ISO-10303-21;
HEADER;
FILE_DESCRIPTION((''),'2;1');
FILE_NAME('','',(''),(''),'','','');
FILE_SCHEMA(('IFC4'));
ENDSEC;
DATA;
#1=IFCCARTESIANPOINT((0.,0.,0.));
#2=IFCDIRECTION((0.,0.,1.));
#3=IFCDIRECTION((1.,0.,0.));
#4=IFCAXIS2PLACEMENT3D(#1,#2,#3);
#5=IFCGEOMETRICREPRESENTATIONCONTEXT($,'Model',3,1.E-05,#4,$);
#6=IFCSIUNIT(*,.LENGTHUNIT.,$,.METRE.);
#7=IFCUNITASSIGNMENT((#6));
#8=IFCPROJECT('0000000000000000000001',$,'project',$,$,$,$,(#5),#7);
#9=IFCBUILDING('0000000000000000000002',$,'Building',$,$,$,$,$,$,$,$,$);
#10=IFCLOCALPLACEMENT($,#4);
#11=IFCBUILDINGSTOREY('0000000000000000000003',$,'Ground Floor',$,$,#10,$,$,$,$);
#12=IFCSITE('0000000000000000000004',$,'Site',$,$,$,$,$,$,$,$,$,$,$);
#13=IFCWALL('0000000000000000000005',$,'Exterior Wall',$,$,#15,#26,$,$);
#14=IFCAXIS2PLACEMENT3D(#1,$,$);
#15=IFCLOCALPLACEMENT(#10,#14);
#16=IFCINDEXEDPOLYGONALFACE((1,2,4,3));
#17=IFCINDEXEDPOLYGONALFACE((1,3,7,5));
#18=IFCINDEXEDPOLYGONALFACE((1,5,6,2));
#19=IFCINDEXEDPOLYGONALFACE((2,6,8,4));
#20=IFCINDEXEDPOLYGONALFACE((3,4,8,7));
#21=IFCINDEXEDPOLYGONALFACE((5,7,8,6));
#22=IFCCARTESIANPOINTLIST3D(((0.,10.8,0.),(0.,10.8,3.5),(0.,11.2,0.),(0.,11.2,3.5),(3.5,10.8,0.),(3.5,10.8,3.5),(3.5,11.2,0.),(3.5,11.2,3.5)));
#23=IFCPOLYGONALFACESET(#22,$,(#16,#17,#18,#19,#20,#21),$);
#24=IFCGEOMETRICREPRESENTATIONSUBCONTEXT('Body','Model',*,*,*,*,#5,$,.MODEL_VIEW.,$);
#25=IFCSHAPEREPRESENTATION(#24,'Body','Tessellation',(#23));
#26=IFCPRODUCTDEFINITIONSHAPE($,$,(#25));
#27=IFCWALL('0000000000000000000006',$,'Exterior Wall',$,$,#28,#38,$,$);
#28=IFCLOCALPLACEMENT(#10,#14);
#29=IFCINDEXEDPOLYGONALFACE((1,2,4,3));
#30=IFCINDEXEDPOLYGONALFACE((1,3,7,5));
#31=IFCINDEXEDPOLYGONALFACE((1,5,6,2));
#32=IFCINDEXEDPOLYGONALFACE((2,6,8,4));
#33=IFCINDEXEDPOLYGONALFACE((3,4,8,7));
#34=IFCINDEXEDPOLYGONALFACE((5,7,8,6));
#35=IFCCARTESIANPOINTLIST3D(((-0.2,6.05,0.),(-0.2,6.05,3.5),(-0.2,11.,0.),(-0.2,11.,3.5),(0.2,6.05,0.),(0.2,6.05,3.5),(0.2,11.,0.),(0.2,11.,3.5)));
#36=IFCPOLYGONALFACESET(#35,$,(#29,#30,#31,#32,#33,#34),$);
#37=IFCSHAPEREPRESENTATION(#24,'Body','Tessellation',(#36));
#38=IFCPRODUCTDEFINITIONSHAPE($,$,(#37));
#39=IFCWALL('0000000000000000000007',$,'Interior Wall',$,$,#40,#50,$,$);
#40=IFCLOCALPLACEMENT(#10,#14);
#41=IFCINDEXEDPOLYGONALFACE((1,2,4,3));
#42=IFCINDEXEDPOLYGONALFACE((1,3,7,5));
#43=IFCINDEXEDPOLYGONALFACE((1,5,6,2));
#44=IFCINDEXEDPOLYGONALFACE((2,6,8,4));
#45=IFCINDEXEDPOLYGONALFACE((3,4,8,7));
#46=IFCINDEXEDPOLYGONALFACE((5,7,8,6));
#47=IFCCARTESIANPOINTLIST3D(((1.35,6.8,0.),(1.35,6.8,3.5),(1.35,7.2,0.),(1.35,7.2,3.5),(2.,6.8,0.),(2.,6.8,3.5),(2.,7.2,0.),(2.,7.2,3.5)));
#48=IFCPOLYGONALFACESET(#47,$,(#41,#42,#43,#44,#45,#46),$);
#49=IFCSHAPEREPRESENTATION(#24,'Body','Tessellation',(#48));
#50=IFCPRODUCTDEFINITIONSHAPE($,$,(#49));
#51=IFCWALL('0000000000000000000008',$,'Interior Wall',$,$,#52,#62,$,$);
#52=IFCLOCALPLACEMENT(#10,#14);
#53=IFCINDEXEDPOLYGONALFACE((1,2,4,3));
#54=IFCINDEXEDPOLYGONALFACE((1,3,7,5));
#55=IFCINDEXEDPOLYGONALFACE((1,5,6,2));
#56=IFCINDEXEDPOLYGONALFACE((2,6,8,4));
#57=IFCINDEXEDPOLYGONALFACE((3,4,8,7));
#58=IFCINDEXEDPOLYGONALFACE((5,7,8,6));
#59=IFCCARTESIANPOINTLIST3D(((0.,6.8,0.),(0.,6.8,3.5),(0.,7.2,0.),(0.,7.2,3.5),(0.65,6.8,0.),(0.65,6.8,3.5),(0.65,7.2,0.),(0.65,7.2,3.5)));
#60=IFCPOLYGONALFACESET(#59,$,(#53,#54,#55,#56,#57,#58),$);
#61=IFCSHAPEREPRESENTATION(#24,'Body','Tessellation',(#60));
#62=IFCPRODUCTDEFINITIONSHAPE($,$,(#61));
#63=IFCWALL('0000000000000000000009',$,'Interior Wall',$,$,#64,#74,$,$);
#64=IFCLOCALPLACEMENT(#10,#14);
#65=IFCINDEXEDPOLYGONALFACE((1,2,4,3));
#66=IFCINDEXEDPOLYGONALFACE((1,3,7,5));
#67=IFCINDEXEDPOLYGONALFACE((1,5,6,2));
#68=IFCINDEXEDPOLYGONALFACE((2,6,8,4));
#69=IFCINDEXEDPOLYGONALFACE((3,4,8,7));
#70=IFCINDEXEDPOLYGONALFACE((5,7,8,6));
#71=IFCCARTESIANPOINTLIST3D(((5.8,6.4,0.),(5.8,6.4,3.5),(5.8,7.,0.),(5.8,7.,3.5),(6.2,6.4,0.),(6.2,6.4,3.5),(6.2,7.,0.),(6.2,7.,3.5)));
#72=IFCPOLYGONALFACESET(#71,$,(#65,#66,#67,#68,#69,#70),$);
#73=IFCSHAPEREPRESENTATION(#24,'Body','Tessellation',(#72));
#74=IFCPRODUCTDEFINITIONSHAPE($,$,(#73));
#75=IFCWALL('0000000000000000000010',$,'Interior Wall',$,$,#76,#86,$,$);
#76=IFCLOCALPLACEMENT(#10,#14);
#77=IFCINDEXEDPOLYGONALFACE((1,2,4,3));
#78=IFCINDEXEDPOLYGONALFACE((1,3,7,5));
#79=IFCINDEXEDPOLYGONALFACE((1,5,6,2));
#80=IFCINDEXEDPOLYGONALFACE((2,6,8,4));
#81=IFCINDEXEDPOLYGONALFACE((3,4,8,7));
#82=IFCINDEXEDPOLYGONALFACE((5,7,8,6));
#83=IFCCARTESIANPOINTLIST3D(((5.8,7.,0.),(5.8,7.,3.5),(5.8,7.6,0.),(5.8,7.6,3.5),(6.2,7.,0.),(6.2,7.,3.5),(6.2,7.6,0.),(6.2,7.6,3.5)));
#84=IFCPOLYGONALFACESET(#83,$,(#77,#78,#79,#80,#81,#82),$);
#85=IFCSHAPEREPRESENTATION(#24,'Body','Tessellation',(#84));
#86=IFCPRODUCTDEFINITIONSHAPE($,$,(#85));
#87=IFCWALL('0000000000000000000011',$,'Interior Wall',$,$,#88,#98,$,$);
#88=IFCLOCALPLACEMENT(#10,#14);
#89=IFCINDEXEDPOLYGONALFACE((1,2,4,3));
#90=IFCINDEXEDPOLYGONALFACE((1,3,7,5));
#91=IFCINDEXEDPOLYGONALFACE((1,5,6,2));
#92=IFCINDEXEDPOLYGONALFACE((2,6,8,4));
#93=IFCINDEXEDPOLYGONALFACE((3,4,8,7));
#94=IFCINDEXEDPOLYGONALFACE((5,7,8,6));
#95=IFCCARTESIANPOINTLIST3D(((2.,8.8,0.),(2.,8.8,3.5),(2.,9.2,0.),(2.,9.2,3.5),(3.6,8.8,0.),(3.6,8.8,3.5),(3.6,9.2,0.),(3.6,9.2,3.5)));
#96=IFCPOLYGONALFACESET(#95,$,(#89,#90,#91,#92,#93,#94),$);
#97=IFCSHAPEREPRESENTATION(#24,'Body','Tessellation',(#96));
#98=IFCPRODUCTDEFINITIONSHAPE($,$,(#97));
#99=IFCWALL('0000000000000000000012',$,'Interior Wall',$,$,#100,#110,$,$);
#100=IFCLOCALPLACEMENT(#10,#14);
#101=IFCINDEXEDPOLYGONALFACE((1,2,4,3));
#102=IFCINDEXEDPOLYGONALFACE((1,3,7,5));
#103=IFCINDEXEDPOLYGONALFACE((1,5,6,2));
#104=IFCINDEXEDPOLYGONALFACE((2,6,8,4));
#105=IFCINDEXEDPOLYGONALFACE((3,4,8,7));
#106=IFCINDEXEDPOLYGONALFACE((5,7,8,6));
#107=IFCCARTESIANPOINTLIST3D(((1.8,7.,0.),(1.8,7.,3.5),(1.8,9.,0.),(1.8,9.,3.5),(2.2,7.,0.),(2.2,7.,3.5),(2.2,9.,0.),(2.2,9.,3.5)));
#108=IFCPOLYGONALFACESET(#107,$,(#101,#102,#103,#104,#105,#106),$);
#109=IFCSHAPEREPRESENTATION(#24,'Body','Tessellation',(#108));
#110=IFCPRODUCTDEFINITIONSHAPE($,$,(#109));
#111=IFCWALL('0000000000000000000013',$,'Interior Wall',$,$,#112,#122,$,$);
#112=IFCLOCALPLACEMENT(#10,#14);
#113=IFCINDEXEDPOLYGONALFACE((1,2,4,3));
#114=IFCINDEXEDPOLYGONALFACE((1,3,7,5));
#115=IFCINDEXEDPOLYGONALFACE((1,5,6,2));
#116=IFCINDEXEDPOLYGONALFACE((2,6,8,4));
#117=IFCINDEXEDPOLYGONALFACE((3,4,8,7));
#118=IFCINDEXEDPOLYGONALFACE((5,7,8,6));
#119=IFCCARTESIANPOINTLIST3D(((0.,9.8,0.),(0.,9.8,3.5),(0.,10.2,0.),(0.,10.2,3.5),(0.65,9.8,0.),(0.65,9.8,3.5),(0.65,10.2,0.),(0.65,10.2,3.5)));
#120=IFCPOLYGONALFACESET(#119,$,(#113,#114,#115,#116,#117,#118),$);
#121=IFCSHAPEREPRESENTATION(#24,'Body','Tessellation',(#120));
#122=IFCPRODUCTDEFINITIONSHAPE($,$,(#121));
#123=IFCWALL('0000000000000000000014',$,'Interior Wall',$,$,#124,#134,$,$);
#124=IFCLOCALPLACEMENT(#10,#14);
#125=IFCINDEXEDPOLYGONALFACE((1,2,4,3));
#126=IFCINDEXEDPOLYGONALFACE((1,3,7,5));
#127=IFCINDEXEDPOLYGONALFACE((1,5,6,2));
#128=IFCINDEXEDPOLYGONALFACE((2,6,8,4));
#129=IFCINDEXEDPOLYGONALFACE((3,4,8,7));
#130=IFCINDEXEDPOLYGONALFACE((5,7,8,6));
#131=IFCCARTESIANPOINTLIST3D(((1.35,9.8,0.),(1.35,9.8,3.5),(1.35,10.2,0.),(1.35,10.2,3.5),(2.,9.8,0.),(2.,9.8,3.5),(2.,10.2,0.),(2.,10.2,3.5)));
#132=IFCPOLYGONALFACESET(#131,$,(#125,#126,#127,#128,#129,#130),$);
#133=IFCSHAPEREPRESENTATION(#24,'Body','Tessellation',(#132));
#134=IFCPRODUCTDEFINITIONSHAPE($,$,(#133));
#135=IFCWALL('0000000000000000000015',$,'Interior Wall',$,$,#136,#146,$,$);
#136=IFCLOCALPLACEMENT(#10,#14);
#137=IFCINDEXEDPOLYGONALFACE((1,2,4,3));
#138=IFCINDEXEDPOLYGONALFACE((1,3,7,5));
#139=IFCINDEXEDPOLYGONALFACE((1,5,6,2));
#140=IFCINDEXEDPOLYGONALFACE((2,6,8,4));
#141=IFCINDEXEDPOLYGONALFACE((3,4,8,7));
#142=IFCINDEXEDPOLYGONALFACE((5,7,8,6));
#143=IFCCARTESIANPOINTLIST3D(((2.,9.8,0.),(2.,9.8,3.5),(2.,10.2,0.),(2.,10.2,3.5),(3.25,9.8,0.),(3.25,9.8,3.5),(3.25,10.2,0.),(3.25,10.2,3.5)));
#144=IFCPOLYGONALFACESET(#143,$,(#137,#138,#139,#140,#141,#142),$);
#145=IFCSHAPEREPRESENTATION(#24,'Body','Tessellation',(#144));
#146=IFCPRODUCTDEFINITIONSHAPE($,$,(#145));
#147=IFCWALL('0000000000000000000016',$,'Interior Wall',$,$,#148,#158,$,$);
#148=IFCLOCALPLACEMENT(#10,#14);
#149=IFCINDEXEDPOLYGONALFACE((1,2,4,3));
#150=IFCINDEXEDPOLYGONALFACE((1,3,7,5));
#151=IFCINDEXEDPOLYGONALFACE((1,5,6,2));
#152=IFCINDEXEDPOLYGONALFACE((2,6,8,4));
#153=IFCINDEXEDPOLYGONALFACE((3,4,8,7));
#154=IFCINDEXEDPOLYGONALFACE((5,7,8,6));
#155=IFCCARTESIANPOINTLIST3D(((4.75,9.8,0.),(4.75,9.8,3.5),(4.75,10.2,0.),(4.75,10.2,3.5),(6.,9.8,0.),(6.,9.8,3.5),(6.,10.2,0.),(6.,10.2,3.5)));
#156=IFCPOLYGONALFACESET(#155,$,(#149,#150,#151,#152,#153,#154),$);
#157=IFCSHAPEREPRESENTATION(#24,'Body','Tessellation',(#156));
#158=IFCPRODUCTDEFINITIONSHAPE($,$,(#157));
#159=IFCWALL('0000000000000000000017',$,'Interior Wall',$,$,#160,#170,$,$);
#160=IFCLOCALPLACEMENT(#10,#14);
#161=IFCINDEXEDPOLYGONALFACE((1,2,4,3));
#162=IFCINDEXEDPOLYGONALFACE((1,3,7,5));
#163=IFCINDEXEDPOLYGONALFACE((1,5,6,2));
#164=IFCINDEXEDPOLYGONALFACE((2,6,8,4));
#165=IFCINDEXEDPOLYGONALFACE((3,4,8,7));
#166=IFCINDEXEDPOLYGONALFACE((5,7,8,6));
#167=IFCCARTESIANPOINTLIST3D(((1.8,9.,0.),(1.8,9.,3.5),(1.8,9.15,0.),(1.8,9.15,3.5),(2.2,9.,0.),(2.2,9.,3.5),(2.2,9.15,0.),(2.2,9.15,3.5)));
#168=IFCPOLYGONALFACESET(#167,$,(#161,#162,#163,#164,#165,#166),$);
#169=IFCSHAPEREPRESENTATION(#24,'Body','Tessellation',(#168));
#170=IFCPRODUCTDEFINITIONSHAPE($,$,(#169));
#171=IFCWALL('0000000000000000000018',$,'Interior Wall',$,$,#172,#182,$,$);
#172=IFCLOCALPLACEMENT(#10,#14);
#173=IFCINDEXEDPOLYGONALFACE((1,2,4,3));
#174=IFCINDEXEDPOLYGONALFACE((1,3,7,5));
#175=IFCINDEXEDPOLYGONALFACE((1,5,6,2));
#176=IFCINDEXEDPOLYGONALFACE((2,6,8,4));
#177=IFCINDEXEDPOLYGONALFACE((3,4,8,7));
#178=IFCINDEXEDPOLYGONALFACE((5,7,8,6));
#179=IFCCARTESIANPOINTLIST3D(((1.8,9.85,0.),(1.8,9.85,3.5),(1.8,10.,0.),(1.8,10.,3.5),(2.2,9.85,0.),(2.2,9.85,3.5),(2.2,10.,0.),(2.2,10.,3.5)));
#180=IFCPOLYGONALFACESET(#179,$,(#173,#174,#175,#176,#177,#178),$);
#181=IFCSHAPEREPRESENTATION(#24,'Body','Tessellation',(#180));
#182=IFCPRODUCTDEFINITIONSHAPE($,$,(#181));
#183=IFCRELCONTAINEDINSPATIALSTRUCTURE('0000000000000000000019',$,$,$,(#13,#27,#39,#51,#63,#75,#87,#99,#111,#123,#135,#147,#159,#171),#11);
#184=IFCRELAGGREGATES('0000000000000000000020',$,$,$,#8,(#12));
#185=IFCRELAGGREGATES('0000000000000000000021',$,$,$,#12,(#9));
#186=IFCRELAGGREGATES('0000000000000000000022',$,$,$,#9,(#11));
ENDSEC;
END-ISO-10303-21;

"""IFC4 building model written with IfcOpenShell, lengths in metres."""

from ifc_helpers import new_model, si_unit, frame, origin_with_axes, place, context, subcontext, project, spatial, indexed_curve, outline, extrude, element, save


model = new_model("IFC4")

# Units and contexts
model_context = context("Model", 3, precision=1e-05, world=origin_with_axes())
body_context = subcontext(model_context, "Body", "Model", "MODEL_VIEW")
ifc_project = project(units=[si_unit("LENGTHUNIT", "METRE")], contexts=[model_context])

# Site, building, storey
site = spatial("IfcSite", under=ifc_project, Name="Site")
building = spatial("IfcBuilding", under=site, Name="Building")
storey_placement = place(None, origin_with_axes())
storey = spatial("IfcBuildingStorey", under=building, at=storey_placement, Name="Ground Floor")

# Walls
wall_1_placement = place(storey_placement, frame((3.5, 11.0, 0.0), z_axis=(0.0, 0.0, 1.0), x_axis=(-1.0, 0.0, 0.0)))
element("IfcWall", 1, at=wall_1_placement, inside=storey, Name="Exterior Wall", context=body_context, shape_type="SweptSolid", body=[
    extrude(outline(indexed_curve([(0.0, 0.0), (0.0, 0.4), (3.5, 0.4), (3.5, 0.0), (0.0, 0.0)], self_intersect=False)), frame((0.0, -0.2, 0.0), z_axis=(0.0, 0.0, 1.0), x_axis=(1.0, 0.0, 0.0)), (0.0, 0.0, 1.0), 3.5),
])
wall_2_placement = place(storey_placement, frame((0.0, 11.0, 0.0), z_axis=(0.0, 0.0, 1.0), x_axis=(0.0, -1.0, 0.0)))
element("IfcWall", 2, at=wall_2_placement, inside=storey, Name="Exterior Wall", context=body_context, shape_type="SweptSolid", body=[
    extrude(outline(indexed_curve([(0.0, 0.0), (0.0, 0.4), (4.95, 0.4), (4.95, 0.0), (0.0, 0.0)], self_intersect=False)), frame((0.0, -0.2, 0.0), z_axis=(0.0, 0.0, 1.0), x_axis=(1.0, 0.0, 0.0)), (0.0, 0.0, 1.0), 3.5),
])
for number, where, z_axis, x_axis, name in (
    (3, (2.0, 7.0, 0.0), (0.0, 0.0, 1.0), (-1.0, 0.0, 0.0), "Interior Wall"),
    (4, (0.65, 7.0, 0.0), (0.0, 0.0, 1.0), (-1.0, 0.0, 0.0), "Interior Wall"),
):
    element("IfcWall", number, at=place(storey_placement, frame(where, z_axis=z_axis, x_axis=x_axis)), inside=storey, Name=name, context=body_context, shape_type="SweptSolid", body=[
        extrude(outline(indexed_curve([(0.0, 0.0), (0.0, 0.4), (0.65, 0.4), (0.65, 0.0), (0.0, 0.0)], self_intersect=False)), frame((0.0, -0.2, 0.0), z_axis=(0.0, 0.0, 1.0), x_axis=(1.0, 0.0, 0.0)), (0.0, 0.0, 1.0), 3.5),
    ])
for number, where, z_axis, x_axis, name in (
    (5, (6.0, 6.4, 0.0), (0.0, 0.0, 1.0), (0.0, 1.0, 0.0), "Interior Wall"),
    (6, (6.0, 7.0, 0.0), (0.0, 0.0, 1.0), (0.0, 1.0, 0.0), "Interior Wall"),
):
    element("IfcWall", number, at=place(storey_placement, frame(where, z_axis=z_axis, x_axis=x_axis)), inside=storey, Name=name, context=body_context, shape_type="SweptSolid", body=[
        extrude(outline(indexed_curve([(0.0, 0.0), (0.0, 0.4), (0.6, 0.4), (0.6, 0.0), (0.0, 0.0)], self_intersect=False)), frame((0.0, -0.2, 0.0), z_axis=(0.0, 0.0, 1.0), x_axis=(1.0, 0.0, 0.0)), (0.0, 0.0, 1.0), 3.5),
    ])
wall_3_placement = place(storey_placement, frame((3.6, 9.0, 0.0), z_axis=(0.0, 0.0, 1.0), x_axis=(-1.0, 0.0, 0.0)))
element("IfcWall", 7, at=wall_3_placement, inside=storey, Name="Interior Wall", context=body_context, shape_type="SweptSolid", body=[
    extrude(outline(indexed_curve([(0.0, 0.0), (0.0, 0.4), (1.6, 0.4), (1.6, 0.0), (0.0, 0.0)], self_intersect=False)), frame((0.0, -0.2, 0.0), z_axis=(0.0, 0.0, 1.0), x_axis=(1.0, 0.0, 0.0)), (0.0, 0.0, 1.0), 3.5),
])
wall_4_placement = place(storey_placement, frame((2.0, 9.0, 0.0), z_axis=(0.0, 0.0, 1.0), x_axis=(0.0, -1.0, 0.0)))
element("IfcWall", 8, at=wall_4_placement, inside=storey, Name="Interior Wall", context=body_context, shape_type="SweptSolid", body=[
    extrude(outline(indexed_curve([(0.0, 0.0), (0.0, 0.4), (2.0, 0.4), (2.0, 0.0), (0.0, 0.0)], self_intersect=False)), frame((0.0, -0.2, 0.0), z_axis=(0.0, 0.0, 1.0), x_axis=(1.0, 0.0, 0.0)), (0.0, 0.0, 1.0), 3.5),
])
wall_5_placement = place(storey_placement, frame((0.0, 10.0, 0.0), z_axis=(0.0, 0.0, 1.0), x_axis=(1.0, 0.0, 0.0)))
element("IfcWall", 9, at=wall_5_placement, inside=storey, Name="Interior Wall", context=body_context, shape_type="SweptSolid", body=[
    extrude(outline(indexed_curve([(0.0, 0.0), (0.0, 0.4), (0.65, 0.4), (0.65, 0.0), (0.0, 0.0)], self_intersect=False)), frame((0.0, -0.2, 0.0), z_axis=(0.0, 0.0, 1.0), x_axis=(1.0, 0.0, 0.0)), (0.0, 0.0, 1.0), 3.5),
])
wall_6_placement = place(storey_placement, frame((1.35, 10.0, 0.0), z_axis=(0.0, 0.0, 1.0), x_axis=(1.0, 0.0, 0.0)))
element("IfcWall", 10, at=wall_6_placement, inside=storey, Name="Interior Wall", context=body_context, shape_type="SweptSolid", body=[
    extrude(outline(indexed_curve([(0.0, 0.0), (0.0, 0.4), (0.65, 0.4), (0.65, 0.0), (0.0, 0.0)], self_intersect=False)), frame((0.0, -0.2, 0.0), z_axis=(0.0, 0.0, 1.0), x_axis=(1.0, 0.0, 0.0)), (0.0, 0.0, 1.0), 3.5),
])
for number, where, z_axis, x_axis, name in (
    (11, (2.0, 10.0, 0.0), (0.0, 0.0, 1.0), (1.0, 0.0, 0.0), "Interior Wall"),
    (12, (4.75, 10.0, 0.0), (0.0, 0.0, 1.0), (1.0, 0.0, 0.0), "Interior Wall"),
):
    element("IfcWall", number, at=place(storey_placement, frame(where, z_axis=z_axis, x_axis=x_axis)), inside=storey, Name=name, context=body_context, shape_type="SweptSolid", body=[
        extrude(outline(indexed_curve([(0.0, 0.0), (0.0, 0.4), (1.25, 0.4), (1.25, 0.0), (0.0, 0.0)], self_intersect=False)), frame((0.0, -0.2, 0.0), z_axis=(0.0, 0.0, 1.0), x_axis=(1.0, 0.0, 0.0)), (0.0, 0.0, 1.0), 3.5),
    ])
for number, where, z_axis, x_axis, name in (
    (13, (2.0, 9.0, 0.0), (0.0, 0.0, 1.0), (0.0, 1.0, 0.0), "Interior Wall"),
    (14, (2.0, 9.85, 0.0), (0.0, 0.0, 1.0), (0.0, 1.0, 0.0), "Interior Wall"),
):
    element("IfcWall", number, at=place(storey_placement, frame(where, z_axis=z_axis, x_axis=x_axis)), inside=storey, Name=name, context=body_context, shape_type="SweptSolid", body=[
        extrude(outline(indexed_curve([(0.0, 0.0), (0.0, 0.4), (0.15, 0.4), (0.15, 0.0), (0.0, 0.0)], self_intersect=False)), frame((0.0, -0.2, 0.0), z_axis=(0.0, 0.0, 1.0), x_axis=(1.0, 0.0, 0.0)), (0.0, 0.0, 1.0), 3.5),
    ])

save(model, "model.ifc")
